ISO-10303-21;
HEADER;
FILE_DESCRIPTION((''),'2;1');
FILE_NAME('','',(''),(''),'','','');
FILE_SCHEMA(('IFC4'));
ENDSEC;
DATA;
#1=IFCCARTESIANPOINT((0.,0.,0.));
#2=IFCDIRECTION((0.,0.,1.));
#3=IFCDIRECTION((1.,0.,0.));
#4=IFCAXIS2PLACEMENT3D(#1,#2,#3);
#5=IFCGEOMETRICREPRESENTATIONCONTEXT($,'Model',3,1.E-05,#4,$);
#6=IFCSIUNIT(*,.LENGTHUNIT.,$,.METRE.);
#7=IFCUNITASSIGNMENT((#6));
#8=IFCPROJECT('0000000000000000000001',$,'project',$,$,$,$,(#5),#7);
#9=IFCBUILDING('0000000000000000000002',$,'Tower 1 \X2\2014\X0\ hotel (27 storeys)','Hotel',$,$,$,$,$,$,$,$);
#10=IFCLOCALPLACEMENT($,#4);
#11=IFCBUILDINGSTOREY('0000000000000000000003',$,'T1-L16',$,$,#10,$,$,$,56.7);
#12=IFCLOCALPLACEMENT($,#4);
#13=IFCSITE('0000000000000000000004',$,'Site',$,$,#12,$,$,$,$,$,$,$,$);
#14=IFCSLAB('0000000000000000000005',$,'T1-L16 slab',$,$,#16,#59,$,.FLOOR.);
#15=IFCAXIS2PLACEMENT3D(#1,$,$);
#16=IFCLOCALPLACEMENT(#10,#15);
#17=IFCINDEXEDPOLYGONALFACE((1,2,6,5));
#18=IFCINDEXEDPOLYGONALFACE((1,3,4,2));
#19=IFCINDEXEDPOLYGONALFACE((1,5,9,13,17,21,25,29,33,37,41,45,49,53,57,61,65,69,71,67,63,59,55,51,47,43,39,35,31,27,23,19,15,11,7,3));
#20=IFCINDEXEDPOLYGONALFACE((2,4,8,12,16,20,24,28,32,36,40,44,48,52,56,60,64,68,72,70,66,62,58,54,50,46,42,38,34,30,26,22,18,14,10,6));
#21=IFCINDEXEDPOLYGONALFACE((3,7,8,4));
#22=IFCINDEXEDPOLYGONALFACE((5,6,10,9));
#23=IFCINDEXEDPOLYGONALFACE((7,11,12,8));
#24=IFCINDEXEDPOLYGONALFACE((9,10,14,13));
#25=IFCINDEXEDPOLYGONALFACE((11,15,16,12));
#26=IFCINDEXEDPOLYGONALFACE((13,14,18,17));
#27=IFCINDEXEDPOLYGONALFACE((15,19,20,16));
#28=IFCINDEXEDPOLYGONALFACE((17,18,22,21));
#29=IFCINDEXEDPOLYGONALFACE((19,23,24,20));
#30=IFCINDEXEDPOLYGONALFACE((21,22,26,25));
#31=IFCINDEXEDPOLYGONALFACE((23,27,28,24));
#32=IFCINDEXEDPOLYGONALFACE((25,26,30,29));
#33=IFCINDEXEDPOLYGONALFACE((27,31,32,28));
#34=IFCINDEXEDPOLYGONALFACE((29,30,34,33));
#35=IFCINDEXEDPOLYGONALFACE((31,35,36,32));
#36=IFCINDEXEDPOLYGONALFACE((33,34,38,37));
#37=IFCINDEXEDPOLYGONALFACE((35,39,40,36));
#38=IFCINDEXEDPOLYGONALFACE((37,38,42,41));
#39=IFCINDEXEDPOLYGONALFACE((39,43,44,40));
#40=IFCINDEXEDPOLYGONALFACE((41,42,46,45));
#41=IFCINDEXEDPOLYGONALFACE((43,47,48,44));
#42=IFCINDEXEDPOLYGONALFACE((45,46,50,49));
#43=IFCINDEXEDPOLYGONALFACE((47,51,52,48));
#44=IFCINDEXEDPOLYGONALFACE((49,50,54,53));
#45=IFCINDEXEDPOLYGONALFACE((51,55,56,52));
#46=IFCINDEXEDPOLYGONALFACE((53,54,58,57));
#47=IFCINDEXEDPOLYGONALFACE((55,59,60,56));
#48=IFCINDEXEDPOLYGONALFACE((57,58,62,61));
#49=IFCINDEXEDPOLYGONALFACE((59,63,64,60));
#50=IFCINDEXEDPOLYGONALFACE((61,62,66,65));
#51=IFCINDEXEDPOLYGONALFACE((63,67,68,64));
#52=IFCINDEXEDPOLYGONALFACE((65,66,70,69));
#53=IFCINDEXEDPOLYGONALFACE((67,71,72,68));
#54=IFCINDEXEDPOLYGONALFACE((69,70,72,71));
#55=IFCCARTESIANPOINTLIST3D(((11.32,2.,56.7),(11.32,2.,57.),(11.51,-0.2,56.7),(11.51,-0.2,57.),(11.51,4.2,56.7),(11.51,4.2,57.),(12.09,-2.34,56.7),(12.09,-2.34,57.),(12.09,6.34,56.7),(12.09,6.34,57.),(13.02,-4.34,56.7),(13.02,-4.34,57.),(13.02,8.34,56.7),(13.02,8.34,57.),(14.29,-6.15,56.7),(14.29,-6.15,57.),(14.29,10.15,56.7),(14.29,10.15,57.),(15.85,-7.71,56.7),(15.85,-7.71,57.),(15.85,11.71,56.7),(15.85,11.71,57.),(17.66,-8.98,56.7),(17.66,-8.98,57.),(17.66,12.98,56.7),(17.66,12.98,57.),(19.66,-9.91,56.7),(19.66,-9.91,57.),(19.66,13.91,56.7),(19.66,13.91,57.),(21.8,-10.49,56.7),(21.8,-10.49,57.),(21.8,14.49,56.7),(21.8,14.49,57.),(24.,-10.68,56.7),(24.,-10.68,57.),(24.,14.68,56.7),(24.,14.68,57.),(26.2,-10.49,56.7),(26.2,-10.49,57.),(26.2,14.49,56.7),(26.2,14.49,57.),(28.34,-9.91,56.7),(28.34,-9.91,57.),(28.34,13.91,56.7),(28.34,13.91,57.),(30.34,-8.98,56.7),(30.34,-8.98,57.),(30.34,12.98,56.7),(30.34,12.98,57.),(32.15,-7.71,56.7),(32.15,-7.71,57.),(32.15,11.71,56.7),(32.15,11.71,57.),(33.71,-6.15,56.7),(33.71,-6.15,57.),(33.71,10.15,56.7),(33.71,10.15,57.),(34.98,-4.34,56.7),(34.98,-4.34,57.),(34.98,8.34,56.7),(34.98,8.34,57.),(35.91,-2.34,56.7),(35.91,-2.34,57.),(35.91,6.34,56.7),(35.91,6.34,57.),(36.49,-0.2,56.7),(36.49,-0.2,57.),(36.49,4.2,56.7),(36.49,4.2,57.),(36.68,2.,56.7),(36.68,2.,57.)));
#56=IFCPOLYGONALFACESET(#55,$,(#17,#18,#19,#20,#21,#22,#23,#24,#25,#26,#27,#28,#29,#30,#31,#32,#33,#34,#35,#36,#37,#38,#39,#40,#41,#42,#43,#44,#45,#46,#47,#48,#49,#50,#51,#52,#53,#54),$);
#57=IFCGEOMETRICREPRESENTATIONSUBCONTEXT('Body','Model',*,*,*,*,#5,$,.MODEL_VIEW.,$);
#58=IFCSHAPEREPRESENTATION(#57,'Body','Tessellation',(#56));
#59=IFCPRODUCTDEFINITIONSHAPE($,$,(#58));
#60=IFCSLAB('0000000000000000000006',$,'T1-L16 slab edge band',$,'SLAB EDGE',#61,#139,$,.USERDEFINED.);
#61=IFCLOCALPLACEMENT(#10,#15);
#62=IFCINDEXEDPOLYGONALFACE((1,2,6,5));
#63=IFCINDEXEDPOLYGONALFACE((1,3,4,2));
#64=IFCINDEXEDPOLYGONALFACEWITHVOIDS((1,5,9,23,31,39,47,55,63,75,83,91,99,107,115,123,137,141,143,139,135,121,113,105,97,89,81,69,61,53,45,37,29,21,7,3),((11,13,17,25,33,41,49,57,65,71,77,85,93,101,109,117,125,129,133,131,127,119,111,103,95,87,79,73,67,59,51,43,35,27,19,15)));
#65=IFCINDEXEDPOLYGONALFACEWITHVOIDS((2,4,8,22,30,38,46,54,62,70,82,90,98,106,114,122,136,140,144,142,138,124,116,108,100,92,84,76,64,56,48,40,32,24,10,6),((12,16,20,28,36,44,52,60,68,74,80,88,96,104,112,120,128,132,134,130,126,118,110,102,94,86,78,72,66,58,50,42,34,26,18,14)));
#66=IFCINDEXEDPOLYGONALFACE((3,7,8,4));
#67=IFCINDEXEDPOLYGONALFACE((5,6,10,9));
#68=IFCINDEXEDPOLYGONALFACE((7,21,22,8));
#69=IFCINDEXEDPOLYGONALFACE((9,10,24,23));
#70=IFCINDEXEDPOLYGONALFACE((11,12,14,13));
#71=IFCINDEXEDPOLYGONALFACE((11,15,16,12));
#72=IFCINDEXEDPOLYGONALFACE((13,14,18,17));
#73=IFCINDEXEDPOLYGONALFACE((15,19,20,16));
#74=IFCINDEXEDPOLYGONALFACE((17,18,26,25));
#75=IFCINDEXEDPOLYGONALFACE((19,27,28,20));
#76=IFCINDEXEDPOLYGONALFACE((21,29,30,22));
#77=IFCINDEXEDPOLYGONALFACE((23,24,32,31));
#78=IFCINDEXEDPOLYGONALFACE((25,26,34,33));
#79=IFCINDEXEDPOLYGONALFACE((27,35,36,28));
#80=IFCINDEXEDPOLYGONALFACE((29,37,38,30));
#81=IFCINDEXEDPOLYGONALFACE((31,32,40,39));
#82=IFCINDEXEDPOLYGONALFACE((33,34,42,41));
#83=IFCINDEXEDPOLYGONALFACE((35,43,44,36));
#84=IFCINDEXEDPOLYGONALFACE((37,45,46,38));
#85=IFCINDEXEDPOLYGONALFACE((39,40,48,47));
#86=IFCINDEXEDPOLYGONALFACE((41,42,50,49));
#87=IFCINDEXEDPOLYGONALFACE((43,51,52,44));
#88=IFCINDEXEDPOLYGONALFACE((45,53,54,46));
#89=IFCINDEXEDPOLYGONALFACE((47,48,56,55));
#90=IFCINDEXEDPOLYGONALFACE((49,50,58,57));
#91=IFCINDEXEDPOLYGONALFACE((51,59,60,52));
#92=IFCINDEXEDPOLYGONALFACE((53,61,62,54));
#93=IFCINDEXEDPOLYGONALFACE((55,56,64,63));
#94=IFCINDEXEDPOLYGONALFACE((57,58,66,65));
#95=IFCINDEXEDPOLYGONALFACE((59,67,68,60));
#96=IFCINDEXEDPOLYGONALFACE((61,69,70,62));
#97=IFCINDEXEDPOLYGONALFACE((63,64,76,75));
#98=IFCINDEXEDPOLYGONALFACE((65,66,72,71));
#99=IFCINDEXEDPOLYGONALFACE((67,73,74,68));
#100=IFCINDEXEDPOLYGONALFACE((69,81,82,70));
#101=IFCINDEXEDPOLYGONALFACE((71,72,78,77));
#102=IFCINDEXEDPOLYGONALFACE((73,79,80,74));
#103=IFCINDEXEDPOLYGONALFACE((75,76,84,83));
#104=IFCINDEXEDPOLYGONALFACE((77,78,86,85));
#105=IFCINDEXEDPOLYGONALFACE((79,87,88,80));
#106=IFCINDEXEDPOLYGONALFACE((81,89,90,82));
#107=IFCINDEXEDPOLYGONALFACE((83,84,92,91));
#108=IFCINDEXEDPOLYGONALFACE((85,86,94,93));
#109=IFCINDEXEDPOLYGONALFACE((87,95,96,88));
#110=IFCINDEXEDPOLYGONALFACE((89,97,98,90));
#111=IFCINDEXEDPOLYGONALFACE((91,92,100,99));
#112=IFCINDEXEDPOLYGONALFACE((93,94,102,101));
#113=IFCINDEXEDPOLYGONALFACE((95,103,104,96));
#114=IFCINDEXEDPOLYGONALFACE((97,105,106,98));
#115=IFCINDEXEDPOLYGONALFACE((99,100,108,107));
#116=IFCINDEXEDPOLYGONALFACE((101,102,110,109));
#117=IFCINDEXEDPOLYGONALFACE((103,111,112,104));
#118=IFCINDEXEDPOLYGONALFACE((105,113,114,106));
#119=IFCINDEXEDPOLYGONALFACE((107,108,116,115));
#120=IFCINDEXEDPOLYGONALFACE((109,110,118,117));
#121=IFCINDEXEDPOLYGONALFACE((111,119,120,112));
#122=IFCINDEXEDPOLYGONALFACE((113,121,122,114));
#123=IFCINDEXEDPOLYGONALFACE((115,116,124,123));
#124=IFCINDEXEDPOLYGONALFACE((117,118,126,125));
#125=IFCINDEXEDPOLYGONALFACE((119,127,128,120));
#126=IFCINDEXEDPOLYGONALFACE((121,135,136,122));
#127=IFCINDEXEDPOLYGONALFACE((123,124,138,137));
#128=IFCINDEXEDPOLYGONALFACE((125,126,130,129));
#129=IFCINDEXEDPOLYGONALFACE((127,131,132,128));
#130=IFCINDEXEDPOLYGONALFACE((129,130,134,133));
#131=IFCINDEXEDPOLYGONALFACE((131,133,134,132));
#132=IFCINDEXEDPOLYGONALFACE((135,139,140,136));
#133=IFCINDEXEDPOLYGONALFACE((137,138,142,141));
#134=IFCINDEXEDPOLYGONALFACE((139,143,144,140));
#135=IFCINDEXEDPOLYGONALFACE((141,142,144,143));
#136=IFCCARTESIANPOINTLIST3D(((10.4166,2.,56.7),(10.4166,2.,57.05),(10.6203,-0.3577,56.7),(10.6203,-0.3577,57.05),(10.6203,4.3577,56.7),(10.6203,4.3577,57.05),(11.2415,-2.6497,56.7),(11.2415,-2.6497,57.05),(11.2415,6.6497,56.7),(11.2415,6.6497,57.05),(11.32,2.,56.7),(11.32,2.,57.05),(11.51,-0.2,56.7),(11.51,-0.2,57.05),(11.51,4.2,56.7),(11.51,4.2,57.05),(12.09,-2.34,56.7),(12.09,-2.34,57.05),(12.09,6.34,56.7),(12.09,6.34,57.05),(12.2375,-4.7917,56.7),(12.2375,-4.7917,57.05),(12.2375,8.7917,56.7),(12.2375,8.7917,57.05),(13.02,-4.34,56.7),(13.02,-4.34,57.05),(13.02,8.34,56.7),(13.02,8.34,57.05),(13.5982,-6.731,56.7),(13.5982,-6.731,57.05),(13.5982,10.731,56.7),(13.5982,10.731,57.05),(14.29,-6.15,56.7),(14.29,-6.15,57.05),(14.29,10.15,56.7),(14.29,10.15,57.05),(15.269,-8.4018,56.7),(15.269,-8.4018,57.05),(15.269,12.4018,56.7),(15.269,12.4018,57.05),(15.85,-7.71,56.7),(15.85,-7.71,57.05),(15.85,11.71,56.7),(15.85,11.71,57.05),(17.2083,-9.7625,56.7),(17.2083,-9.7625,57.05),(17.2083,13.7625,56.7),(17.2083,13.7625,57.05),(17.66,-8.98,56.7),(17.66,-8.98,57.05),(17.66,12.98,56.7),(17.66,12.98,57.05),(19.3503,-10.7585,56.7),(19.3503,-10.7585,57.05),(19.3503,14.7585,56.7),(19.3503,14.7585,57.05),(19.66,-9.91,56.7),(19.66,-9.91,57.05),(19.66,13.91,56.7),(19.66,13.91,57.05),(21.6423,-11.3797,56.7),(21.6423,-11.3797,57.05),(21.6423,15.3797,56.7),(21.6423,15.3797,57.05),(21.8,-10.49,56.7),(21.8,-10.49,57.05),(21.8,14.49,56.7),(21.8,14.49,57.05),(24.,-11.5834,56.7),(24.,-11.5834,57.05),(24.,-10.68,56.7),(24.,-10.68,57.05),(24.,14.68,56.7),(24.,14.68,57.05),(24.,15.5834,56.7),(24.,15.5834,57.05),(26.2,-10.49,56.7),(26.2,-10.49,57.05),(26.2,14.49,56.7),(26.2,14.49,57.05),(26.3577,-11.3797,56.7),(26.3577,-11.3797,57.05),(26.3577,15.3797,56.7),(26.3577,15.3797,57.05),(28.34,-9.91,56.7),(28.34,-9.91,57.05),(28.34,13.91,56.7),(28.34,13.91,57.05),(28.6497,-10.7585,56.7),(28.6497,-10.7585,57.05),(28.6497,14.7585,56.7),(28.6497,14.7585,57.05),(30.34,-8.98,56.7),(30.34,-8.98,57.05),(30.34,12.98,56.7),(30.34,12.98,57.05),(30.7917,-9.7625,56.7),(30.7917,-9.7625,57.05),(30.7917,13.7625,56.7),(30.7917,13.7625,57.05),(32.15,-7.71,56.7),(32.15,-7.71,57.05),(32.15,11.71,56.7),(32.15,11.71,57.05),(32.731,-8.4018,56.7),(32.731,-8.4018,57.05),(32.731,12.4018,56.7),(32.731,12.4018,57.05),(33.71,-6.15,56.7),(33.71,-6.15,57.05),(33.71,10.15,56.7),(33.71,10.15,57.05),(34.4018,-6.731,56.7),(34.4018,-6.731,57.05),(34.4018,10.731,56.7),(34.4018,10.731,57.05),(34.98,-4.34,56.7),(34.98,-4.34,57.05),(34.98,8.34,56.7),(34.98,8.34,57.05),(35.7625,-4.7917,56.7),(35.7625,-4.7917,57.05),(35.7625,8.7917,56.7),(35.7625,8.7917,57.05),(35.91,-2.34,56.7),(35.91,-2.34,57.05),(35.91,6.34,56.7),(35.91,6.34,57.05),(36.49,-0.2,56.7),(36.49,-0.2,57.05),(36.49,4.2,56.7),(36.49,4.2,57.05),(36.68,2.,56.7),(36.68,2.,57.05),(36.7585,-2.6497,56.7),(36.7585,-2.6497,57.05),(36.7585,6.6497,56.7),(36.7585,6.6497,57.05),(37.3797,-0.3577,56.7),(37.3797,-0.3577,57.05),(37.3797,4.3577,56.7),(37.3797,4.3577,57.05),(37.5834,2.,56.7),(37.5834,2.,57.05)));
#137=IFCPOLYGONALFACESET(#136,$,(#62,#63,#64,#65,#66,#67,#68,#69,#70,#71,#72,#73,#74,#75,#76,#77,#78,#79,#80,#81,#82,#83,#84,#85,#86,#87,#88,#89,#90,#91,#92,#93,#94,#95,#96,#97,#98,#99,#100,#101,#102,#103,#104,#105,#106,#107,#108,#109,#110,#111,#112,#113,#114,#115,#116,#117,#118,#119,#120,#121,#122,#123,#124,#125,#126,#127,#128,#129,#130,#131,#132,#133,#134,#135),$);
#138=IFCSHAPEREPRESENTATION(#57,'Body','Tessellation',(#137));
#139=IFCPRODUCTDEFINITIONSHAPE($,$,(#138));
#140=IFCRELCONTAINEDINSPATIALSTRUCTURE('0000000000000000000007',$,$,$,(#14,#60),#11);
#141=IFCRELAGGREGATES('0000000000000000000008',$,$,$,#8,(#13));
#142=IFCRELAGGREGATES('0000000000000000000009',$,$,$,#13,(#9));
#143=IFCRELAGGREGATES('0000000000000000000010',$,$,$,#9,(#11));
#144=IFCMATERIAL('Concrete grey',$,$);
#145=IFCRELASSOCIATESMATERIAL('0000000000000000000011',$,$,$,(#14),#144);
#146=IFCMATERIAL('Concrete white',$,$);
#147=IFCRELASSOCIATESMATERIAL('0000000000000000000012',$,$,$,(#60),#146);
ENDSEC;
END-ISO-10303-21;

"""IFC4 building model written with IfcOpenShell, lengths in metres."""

from ifc_helpers import new_model, si_unit, frame, origin_with_axes, place, context, subcontext, project, spatial, polyline, outline, extrude, material, element, save


model = new_model("IFC4")

# Units and contexts
model_context = context("Model", 3, precision=1e-05, world=origin_with_axes())
body_context = subcontext(model_context, "Body", "Model", "MODEL_VIEW")
ifc_project = project(units=[si_unit("LENGTHUNIT", "METRE")], contexts=[model_context])

# Site, building, storey
site_placement = place(None, origin_with_axes())
site = spatial("IfcSite", under=ifc_project, at=site_placement, Name="Site")
building = spatial("IfcBuilding", under=site, Name="Tower 1 — hotel (27 storeys)", Description="Hotel")
storey_placement = place(None, origin_with_axes())
storey = spatial("IfcBuildingStorey", under=building, at=storey_placement, Name="T1-L16", Elevation=56.7)

# Slab
ifc_material_1 = material(Name="Concrete grey")
slab_1_placement = place(storey_placement, origin_with_axes())
element("IfcSlab", 1, at=slab_1_placement, inside=storey, material=ifc_material_1, Name="T1-L16 slab", PredefinedType="FLOOR", context=body_context, shape_type="SweptSolid", body=[
    extrude(outline(polyline([(36.68, 2.0), (36.49, 4.2), (35.91, 6.34), (34.98, 8.34), (33.71, 10.15), (32.15, 11.71), (30.34, 12.98), (28.34, 13.91), (26.2, 14.49), (24.0, 14.68), (21.8, 14.49), (19.66, 13.91), (17.66, 12.98), (15.85, 11.71), (14.29, 10.15), (13.02, 8.34), (12.09, 6.34), (11.51, 4.2), (11.32, 2.0), (11.51, -0.2), (12.09, -2.34), (13.02, -4.34), (14.29, -6.15), (15.85, -7.71), (17.66, -8.98), (19.66, -9.91), (21.8, -10.49), (24.0, -10.68), (26.2, -10.49), (28.34, -9.91), (30.34, -8.98), (32.15, -7.71), (33.71, -6.15), (34.98, -4.34), (35.91, -2.34), (36.49, -0.2), (36.68, 2.0)])), frame((0.0, 0.0, 56.7), z_axis=(0.0, 0.0, 1.0), x_axis=(1.0, 0.0, 0.0)), (0.0, 0.0, 1.0), 0.3),
])

# Slab
ifc_material_2 = material(Name="Concrete white")
slab_2_placement = place(storey_placement, origin_with_axes())
element("IfcSlab", 2, at=slab_2_placement, inside=storey, material=ifc_material_2, Name="T1-L16 slab edge band", ObjectType="SLAB EDGE", PredefinedType="USERDEFINED", context=body_context, shape_type="SweptSolid", body=[
    extrude(outline(polyline([(37.5834, 2.0), (37.3797, 4.3577), (36.7585, 6.6497), (35.7625, 8.7917), (34.4018, 10.731), (32.731, 12.4018), (30.7917, 13.7625), (28.6497, 14.7585), (26.3577, 15.3797), (24.0, 15.5834), (21.6423, 15.3797), (19.3503, 14.7585), (17.2083, 13.7625), (15.269, 12.4018), (13.5982, 10.731), (12.2375, 8.7917), (11.2415, 6.6497), (10.6203, 4.3577), (10.4166, 2.0), (10.6203, -0.3577), (11.2415, -2.6497), (12.2375, -4.7917), (13.5982, -6.731), (15.269, -8.4018), (17.2083, -9.7625), (19.3503, -10.7585), (21.6423, -11.3797), (24.0, -11.5834), (26.3577, -11.3797), (28.6497, -10.7585), (30.7917, -9.7625), (32.731, -8.4018), (34.4018, -6.731), (35.7625, -4.7917), (36.7585, -2.6497), (37.3797, -0.3577), (37.5834, 2.0)]), holes=[polyline([(36.68, 2.0), (36.49, 4.2), (35.91, 6.34), (34.98, 8.34), (33.71, 10.15), (32.15, 11.71), (30.34, 12.98), (28.34, 13.91), (26.2, 14.49), (24.0, 14.68), (21.8, 14.49), (19.66, 13.91), (17.66, 12.98), (15.85, 11.71), (14.29, 10.15), (13.02, 8.34), (12.09, 6.34), (11.51, 4.2), (11.32, 2.0), (11.51, -0.2), (12.09, -2.34), (13.02, -4.34), (14.29, -6.15), (15.85, -7.71), (17.66, -8.98), (19.66, -9.91), (21.8, -10.49), (24.0, -10.68), (26.2, -10.49), (28.34, -9.91), (30.34, -8.98), (32.15, -7.71), (33.71, -6.15), (34.98, -4.34), (35.91, -2.34), (36.49, -0.2), (36.68, 2.0)])]), frame((0.0, 0.0, 56.7), z_axis=(0.0, 0.0, 1.0), x_axis=(1.0, 0.0, 0.0)), (0.0, 0.0, 1.0), 0.35),
])

save(model, "model.ifc")
